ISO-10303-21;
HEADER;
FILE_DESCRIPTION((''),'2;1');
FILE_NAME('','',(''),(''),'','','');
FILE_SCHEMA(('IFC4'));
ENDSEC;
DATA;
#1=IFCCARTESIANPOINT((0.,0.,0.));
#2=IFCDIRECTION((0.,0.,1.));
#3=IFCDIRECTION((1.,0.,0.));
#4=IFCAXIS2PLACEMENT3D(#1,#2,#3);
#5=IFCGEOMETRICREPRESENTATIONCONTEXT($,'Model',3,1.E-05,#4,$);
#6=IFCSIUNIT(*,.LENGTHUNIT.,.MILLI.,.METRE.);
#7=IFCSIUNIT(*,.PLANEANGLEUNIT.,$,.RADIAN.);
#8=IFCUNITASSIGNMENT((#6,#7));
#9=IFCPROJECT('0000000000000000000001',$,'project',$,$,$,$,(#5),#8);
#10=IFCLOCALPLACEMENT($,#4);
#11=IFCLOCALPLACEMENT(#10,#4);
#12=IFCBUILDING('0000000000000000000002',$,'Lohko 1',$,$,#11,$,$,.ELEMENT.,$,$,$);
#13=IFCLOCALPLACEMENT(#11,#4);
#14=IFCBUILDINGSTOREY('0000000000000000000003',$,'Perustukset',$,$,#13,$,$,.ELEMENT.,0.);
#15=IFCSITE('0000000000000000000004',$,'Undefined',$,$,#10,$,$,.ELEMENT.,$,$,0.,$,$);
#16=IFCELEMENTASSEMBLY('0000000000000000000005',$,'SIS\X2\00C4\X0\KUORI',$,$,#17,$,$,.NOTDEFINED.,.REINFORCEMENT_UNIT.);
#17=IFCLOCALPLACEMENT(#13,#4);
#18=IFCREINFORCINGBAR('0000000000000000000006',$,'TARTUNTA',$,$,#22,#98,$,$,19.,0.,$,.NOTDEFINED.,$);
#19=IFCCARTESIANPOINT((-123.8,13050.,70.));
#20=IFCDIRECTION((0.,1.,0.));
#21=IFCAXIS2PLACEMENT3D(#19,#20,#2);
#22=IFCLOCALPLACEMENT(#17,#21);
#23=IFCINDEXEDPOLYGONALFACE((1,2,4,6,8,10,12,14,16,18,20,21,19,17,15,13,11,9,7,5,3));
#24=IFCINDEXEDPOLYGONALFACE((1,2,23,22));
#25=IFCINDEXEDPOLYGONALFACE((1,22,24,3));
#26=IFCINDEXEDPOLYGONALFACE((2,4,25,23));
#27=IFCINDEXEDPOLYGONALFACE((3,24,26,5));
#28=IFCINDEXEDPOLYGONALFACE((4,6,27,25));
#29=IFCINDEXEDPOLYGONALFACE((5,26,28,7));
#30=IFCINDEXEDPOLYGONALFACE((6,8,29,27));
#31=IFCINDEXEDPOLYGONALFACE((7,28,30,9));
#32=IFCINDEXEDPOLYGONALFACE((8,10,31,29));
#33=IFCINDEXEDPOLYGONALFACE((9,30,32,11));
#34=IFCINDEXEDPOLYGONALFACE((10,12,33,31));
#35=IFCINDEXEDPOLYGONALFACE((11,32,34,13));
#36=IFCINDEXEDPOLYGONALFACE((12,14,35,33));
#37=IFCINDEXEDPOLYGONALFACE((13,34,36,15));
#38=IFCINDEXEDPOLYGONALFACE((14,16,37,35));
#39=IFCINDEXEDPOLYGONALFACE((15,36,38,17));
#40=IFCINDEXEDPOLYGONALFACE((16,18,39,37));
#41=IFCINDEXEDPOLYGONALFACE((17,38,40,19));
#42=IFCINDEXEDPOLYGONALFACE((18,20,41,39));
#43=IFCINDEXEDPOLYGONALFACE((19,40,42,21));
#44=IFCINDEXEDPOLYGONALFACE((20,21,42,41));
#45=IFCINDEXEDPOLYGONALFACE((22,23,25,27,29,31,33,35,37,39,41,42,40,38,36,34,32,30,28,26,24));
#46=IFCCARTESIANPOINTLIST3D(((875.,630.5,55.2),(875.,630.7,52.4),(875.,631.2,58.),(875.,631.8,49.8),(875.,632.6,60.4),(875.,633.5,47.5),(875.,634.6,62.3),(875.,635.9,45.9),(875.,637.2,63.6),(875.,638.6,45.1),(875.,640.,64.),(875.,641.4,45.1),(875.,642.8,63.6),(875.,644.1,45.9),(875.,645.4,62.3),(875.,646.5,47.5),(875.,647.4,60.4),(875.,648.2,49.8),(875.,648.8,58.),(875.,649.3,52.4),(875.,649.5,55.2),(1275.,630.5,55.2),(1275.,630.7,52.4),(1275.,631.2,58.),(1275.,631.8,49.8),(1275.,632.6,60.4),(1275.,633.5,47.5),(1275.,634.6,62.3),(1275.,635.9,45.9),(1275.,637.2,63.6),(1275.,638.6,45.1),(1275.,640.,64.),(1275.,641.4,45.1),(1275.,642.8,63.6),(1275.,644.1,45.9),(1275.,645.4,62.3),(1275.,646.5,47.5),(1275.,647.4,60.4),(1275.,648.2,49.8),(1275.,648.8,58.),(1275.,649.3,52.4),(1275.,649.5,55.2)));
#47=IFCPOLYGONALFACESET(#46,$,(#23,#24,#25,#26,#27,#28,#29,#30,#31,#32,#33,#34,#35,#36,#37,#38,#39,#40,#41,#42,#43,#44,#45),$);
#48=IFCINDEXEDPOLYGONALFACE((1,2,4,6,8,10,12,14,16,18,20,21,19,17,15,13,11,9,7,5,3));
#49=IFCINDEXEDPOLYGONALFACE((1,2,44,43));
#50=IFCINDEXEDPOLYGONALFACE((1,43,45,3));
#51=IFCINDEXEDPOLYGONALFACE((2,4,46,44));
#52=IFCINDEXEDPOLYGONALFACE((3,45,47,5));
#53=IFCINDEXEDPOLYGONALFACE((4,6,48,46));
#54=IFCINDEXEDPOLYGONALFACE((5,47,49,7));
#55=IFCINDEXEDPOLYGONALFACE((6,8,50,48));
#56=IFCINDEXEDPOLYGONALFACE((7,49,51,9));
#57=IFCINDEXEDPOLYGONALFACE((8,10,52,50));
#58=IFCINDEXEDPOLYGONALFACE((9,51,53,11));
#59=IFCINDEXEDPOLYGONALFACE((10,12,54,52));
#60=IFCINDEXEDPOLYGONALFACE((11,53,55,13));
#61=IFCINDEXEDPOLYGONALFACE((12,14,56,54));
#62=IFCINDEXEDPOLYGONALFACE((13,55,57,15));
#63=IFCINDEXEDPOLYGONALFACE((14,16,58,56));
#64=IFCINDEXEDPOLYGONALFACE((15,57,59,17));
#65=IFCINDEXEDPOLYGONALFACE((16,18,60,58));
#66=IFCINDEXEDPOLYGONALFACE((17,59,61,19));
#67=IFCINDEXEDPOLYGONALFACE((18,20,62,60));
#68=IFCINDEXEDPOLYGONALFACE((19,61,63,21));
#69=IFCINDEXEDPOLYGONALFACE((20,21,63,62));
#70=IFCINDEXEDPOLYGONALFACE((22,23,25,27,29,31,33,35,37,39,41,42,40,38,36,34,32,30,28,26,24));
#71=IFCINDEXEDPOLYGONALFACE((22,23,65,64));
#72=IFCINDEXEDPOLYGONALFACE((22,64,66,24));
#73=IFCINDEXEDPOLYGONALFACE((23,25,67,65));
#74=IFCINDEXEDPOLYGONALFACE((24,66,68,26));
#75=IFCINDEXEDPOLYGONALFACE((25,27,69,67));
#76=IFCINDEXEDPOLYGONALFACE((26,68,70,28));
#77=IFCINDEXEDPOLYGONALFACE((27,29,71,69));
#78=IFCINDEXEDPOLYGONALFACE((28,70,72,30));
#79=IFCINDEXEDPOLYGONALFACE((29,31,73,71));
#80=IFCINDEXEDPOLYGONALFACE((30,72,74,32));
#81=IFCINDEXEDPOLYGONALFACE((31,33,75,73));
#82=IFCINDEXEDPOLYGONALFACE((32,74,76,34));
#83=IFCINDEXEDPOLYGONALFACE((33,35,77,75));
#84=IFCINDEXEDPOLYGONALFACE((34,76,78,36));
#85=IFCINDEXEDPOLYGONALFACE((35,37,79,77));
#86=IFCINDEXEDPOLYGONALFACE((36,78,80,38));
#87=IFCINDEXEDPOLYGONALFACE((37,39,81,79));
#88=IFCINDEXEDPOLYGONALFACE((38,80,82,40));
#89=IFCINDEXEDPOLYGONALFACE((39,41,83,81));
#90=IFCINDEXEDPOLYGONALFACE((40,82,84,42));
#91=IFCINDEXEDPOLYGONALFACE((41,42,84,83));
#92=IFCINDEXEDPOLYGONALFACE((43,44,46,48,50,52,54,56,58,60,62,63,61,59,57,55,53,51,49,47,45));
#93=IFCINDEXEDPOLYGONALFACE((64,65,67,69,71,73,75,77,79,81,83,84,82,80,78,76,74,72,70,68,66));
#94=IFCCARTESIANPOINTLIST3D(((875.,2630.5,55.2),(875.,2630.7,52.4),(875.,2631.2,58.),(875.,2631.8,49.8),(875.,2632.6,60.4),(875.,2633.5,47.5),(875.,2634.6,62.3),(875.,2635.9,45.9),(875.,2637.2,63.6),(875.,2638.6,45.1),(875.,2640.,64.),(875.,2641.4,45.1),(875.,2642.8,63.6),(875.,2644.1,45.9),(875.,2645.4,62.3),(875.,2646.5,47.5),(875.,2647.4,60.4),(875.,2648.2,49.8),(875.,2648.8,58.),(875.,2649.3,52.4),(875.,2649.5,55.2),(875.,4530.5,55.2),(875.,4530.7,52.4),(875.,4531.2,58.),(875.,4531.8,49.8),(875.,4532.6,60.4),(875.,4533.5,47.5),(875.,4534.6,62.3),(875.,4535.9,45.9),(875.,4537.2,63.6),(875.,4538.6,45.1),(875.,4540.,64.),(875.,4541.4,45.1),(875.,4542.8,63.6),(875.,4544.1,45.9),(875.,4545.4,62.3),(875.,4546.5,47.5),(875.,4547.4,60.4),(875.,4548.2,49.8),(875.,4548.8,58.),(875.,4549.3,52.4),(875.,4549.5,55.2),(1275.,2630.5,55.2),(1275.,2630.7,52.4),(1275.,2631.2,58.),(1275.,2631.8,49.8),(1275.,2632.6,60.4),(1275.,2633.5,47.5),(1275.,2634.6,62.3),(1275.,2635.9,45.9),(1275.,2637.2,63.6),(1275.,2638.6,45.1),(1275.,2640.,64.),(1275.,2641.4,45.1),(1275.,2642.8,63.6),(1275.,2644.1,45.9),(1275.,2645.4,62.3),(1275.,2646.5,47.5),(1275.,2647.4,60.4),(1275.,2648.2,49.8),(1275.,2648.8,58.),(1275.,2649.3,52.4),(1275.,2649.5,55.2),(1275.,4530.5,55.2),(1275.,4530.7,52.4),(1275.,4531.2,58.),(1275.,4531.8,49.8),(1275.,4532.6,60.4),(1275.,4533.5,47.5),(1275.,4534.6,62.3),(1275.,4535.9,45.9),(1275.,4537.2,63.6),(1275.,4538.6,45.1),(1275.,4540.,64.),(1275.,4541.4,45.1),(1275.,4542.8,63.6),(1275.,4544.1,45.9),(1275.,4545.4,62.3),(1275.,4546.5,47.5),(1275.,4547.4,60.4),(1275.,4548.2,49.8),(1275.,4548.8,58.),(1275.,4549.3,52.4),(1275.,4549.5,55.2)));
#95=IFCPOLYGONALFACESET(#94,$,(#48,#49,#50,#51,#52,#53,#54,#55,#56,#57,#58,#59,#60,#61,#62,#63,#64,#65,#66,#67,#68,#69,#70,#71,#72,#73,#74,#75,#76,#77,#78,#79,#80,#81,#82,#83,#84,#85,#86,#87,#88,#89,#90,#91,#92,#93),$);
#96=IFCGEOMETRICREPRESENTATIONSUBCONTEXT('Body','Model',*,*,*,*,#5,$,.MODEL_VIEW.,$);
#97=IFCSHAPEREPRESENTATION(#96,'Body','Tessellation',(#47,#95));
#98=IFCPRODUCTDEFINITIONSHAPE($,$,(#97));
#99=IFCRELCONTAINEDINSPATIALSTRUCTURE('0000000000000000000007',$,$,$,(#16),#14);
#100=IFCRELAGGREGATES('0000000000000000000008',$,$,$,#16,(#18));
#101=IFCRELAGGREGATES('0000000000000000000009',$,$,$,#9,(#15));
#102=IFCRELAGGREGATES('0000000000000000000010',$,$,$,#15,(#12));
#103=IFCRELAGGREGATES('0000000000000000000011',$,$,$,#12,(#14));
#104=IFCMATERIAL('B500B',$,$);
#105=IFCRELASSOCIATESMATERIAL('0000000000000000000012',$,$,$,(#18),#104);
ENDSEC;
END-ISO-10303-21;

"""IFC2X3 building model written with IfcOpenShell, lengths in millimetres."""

from ifc_helpers import new_model, entity, si_unit, frame, origin_with_axes, place, context, subcontext, project, spatial, source, transform, mapped, material, element, aggregate, save


model = new_model("IFC2X3")

# Units and contexts
model_context = context("Model", 3, precision=1e-05, world=origin_with_axes())
body_context = subcontext(model_context, "Body", "Model", "MODEL_VIEW")
ifc_project = project(units=[si_unit("LENGTHUNIT", "METRE", prefix="MILLI"), si_unit("PLANEANGLEUNIT", "RADIAN")], contexts=[model_context])

# Site, building, storey
site_placement = place(None, origin_with_axes())
site = spatial("IfcSite", under=ifc_project, at=site_placement, Name="Undefined", CompositionType="ELEMENT", RefElevation=0.0)
building_placement = place(site_placement, origin_with_axes())
building = spatial("IfcBuilding", under=site, at=building_placement, Name="Lohko 1", CompositionType="ELEMENT")
storey_placement = place(building_placement, origin_with_axes())
storey = spatial("IfcBuildingStorey", under=building, at=storey_placement, Name="Perustukset", CompositionType="ELEMENT", Elevation=0.0)

# Element assembly, reinforcing bar
assembly_placement = place(storey_placement, origin_with_axes())
assembly = element("IfcElementAssembly", 1, at=assembly_placement, inside=storey, Name="SISÄKUORI", AssemblyPlace="NOTDEFINED", PredefinedType="REINFORCEMENT_UNIT")
ifc_material_1 = material(Name="B500B")
shared_shape_1 = source(origin_with_axes(), body_context, "Body", "AdvancedSweptSolid", [
    entity("IfcSweptDiskSolid", entity("IfcTrimmedCurve", entity("IfcLine", entity("IfcCartesianPoint", [0.0, 0.0, 0.0]), entity("IfcVector", entity("IfcDirection", [1.0, 0.0, 0.0]), 1.0)), [entity("IfcParameterValue", 0.0)], [entity("IfcParameterValue", 400.0)], True, "PARAMETER"), 9.5, None, 0.0, 400.0),
])
shared_shape_2 = source(origin_with_axes(), body_context, "Body", "AdvancedSweptSolid", [
    entity("IfcSweptDiskSolid", entity("IfcTrimmedCurve", entity("IfcLine", entity("IfcCartesianPoint", [0.0, 0.0, 0.0]), entity("IfcVector", entity("IfcDirection", [1.0, 0.0, 0.0]), 1.0)), [entity("IfcParameterValue", 0.0)], [entity("IfcParameterValue", 400.0)], True, "PARAMETER"), 9.5, None, 0.0, 400.0),
])
shared_shape_3 = source(origin_with_axes(), body_context, "Body", "AdvancedSweptSolid", [
    entity("IfcSweptDiskSolid", entity("IfcTrimmedCurve", entity("IfcLine", entity("IfcCartesianPoint", [0.0, 0.0, 0.0]), entity("IfcVector", entity("IfcDirection", [1.0, 0.0, 0.0]), 1.0)), [entity("IfcParameterValue", 0.0)], [entity("IfcParameterValue", 400.0)], True, "PARAMETER"), 9.5, None, 0.0, 400.0),
])
reinforcing_bar_1_placement = place(assembly_placement, frame((-123.8, 13050.0, 70.0), z_axis=(0.0, 1.0, 0.0), x_axis=(0.0, 0.0, 1.0)))
reinforcing_bar_1 = element("IfcReinforcingBar", 2, at=reinforcing_bar_1_placement, material=ifc_material_1, Name="TARTUNTA", BarRole="NOTDEFINED", CrossSectionArea=0.0, NominalDiameter=19.0, context=body_context, shape_type="MappedRepresentation", body=[
    mapped(shared_shape_1, transform((875.0, 640.0, 54.5))),
    mapped(shared_shape_2, transform((875.0, 2640.0, 54.5))),
    mapped(shared_shape_3, transform((875.0, 4540.0, 54.5))),
])
aggregate(assembly, [reinforcing_bar_1])

save(model, "model.ifc")
